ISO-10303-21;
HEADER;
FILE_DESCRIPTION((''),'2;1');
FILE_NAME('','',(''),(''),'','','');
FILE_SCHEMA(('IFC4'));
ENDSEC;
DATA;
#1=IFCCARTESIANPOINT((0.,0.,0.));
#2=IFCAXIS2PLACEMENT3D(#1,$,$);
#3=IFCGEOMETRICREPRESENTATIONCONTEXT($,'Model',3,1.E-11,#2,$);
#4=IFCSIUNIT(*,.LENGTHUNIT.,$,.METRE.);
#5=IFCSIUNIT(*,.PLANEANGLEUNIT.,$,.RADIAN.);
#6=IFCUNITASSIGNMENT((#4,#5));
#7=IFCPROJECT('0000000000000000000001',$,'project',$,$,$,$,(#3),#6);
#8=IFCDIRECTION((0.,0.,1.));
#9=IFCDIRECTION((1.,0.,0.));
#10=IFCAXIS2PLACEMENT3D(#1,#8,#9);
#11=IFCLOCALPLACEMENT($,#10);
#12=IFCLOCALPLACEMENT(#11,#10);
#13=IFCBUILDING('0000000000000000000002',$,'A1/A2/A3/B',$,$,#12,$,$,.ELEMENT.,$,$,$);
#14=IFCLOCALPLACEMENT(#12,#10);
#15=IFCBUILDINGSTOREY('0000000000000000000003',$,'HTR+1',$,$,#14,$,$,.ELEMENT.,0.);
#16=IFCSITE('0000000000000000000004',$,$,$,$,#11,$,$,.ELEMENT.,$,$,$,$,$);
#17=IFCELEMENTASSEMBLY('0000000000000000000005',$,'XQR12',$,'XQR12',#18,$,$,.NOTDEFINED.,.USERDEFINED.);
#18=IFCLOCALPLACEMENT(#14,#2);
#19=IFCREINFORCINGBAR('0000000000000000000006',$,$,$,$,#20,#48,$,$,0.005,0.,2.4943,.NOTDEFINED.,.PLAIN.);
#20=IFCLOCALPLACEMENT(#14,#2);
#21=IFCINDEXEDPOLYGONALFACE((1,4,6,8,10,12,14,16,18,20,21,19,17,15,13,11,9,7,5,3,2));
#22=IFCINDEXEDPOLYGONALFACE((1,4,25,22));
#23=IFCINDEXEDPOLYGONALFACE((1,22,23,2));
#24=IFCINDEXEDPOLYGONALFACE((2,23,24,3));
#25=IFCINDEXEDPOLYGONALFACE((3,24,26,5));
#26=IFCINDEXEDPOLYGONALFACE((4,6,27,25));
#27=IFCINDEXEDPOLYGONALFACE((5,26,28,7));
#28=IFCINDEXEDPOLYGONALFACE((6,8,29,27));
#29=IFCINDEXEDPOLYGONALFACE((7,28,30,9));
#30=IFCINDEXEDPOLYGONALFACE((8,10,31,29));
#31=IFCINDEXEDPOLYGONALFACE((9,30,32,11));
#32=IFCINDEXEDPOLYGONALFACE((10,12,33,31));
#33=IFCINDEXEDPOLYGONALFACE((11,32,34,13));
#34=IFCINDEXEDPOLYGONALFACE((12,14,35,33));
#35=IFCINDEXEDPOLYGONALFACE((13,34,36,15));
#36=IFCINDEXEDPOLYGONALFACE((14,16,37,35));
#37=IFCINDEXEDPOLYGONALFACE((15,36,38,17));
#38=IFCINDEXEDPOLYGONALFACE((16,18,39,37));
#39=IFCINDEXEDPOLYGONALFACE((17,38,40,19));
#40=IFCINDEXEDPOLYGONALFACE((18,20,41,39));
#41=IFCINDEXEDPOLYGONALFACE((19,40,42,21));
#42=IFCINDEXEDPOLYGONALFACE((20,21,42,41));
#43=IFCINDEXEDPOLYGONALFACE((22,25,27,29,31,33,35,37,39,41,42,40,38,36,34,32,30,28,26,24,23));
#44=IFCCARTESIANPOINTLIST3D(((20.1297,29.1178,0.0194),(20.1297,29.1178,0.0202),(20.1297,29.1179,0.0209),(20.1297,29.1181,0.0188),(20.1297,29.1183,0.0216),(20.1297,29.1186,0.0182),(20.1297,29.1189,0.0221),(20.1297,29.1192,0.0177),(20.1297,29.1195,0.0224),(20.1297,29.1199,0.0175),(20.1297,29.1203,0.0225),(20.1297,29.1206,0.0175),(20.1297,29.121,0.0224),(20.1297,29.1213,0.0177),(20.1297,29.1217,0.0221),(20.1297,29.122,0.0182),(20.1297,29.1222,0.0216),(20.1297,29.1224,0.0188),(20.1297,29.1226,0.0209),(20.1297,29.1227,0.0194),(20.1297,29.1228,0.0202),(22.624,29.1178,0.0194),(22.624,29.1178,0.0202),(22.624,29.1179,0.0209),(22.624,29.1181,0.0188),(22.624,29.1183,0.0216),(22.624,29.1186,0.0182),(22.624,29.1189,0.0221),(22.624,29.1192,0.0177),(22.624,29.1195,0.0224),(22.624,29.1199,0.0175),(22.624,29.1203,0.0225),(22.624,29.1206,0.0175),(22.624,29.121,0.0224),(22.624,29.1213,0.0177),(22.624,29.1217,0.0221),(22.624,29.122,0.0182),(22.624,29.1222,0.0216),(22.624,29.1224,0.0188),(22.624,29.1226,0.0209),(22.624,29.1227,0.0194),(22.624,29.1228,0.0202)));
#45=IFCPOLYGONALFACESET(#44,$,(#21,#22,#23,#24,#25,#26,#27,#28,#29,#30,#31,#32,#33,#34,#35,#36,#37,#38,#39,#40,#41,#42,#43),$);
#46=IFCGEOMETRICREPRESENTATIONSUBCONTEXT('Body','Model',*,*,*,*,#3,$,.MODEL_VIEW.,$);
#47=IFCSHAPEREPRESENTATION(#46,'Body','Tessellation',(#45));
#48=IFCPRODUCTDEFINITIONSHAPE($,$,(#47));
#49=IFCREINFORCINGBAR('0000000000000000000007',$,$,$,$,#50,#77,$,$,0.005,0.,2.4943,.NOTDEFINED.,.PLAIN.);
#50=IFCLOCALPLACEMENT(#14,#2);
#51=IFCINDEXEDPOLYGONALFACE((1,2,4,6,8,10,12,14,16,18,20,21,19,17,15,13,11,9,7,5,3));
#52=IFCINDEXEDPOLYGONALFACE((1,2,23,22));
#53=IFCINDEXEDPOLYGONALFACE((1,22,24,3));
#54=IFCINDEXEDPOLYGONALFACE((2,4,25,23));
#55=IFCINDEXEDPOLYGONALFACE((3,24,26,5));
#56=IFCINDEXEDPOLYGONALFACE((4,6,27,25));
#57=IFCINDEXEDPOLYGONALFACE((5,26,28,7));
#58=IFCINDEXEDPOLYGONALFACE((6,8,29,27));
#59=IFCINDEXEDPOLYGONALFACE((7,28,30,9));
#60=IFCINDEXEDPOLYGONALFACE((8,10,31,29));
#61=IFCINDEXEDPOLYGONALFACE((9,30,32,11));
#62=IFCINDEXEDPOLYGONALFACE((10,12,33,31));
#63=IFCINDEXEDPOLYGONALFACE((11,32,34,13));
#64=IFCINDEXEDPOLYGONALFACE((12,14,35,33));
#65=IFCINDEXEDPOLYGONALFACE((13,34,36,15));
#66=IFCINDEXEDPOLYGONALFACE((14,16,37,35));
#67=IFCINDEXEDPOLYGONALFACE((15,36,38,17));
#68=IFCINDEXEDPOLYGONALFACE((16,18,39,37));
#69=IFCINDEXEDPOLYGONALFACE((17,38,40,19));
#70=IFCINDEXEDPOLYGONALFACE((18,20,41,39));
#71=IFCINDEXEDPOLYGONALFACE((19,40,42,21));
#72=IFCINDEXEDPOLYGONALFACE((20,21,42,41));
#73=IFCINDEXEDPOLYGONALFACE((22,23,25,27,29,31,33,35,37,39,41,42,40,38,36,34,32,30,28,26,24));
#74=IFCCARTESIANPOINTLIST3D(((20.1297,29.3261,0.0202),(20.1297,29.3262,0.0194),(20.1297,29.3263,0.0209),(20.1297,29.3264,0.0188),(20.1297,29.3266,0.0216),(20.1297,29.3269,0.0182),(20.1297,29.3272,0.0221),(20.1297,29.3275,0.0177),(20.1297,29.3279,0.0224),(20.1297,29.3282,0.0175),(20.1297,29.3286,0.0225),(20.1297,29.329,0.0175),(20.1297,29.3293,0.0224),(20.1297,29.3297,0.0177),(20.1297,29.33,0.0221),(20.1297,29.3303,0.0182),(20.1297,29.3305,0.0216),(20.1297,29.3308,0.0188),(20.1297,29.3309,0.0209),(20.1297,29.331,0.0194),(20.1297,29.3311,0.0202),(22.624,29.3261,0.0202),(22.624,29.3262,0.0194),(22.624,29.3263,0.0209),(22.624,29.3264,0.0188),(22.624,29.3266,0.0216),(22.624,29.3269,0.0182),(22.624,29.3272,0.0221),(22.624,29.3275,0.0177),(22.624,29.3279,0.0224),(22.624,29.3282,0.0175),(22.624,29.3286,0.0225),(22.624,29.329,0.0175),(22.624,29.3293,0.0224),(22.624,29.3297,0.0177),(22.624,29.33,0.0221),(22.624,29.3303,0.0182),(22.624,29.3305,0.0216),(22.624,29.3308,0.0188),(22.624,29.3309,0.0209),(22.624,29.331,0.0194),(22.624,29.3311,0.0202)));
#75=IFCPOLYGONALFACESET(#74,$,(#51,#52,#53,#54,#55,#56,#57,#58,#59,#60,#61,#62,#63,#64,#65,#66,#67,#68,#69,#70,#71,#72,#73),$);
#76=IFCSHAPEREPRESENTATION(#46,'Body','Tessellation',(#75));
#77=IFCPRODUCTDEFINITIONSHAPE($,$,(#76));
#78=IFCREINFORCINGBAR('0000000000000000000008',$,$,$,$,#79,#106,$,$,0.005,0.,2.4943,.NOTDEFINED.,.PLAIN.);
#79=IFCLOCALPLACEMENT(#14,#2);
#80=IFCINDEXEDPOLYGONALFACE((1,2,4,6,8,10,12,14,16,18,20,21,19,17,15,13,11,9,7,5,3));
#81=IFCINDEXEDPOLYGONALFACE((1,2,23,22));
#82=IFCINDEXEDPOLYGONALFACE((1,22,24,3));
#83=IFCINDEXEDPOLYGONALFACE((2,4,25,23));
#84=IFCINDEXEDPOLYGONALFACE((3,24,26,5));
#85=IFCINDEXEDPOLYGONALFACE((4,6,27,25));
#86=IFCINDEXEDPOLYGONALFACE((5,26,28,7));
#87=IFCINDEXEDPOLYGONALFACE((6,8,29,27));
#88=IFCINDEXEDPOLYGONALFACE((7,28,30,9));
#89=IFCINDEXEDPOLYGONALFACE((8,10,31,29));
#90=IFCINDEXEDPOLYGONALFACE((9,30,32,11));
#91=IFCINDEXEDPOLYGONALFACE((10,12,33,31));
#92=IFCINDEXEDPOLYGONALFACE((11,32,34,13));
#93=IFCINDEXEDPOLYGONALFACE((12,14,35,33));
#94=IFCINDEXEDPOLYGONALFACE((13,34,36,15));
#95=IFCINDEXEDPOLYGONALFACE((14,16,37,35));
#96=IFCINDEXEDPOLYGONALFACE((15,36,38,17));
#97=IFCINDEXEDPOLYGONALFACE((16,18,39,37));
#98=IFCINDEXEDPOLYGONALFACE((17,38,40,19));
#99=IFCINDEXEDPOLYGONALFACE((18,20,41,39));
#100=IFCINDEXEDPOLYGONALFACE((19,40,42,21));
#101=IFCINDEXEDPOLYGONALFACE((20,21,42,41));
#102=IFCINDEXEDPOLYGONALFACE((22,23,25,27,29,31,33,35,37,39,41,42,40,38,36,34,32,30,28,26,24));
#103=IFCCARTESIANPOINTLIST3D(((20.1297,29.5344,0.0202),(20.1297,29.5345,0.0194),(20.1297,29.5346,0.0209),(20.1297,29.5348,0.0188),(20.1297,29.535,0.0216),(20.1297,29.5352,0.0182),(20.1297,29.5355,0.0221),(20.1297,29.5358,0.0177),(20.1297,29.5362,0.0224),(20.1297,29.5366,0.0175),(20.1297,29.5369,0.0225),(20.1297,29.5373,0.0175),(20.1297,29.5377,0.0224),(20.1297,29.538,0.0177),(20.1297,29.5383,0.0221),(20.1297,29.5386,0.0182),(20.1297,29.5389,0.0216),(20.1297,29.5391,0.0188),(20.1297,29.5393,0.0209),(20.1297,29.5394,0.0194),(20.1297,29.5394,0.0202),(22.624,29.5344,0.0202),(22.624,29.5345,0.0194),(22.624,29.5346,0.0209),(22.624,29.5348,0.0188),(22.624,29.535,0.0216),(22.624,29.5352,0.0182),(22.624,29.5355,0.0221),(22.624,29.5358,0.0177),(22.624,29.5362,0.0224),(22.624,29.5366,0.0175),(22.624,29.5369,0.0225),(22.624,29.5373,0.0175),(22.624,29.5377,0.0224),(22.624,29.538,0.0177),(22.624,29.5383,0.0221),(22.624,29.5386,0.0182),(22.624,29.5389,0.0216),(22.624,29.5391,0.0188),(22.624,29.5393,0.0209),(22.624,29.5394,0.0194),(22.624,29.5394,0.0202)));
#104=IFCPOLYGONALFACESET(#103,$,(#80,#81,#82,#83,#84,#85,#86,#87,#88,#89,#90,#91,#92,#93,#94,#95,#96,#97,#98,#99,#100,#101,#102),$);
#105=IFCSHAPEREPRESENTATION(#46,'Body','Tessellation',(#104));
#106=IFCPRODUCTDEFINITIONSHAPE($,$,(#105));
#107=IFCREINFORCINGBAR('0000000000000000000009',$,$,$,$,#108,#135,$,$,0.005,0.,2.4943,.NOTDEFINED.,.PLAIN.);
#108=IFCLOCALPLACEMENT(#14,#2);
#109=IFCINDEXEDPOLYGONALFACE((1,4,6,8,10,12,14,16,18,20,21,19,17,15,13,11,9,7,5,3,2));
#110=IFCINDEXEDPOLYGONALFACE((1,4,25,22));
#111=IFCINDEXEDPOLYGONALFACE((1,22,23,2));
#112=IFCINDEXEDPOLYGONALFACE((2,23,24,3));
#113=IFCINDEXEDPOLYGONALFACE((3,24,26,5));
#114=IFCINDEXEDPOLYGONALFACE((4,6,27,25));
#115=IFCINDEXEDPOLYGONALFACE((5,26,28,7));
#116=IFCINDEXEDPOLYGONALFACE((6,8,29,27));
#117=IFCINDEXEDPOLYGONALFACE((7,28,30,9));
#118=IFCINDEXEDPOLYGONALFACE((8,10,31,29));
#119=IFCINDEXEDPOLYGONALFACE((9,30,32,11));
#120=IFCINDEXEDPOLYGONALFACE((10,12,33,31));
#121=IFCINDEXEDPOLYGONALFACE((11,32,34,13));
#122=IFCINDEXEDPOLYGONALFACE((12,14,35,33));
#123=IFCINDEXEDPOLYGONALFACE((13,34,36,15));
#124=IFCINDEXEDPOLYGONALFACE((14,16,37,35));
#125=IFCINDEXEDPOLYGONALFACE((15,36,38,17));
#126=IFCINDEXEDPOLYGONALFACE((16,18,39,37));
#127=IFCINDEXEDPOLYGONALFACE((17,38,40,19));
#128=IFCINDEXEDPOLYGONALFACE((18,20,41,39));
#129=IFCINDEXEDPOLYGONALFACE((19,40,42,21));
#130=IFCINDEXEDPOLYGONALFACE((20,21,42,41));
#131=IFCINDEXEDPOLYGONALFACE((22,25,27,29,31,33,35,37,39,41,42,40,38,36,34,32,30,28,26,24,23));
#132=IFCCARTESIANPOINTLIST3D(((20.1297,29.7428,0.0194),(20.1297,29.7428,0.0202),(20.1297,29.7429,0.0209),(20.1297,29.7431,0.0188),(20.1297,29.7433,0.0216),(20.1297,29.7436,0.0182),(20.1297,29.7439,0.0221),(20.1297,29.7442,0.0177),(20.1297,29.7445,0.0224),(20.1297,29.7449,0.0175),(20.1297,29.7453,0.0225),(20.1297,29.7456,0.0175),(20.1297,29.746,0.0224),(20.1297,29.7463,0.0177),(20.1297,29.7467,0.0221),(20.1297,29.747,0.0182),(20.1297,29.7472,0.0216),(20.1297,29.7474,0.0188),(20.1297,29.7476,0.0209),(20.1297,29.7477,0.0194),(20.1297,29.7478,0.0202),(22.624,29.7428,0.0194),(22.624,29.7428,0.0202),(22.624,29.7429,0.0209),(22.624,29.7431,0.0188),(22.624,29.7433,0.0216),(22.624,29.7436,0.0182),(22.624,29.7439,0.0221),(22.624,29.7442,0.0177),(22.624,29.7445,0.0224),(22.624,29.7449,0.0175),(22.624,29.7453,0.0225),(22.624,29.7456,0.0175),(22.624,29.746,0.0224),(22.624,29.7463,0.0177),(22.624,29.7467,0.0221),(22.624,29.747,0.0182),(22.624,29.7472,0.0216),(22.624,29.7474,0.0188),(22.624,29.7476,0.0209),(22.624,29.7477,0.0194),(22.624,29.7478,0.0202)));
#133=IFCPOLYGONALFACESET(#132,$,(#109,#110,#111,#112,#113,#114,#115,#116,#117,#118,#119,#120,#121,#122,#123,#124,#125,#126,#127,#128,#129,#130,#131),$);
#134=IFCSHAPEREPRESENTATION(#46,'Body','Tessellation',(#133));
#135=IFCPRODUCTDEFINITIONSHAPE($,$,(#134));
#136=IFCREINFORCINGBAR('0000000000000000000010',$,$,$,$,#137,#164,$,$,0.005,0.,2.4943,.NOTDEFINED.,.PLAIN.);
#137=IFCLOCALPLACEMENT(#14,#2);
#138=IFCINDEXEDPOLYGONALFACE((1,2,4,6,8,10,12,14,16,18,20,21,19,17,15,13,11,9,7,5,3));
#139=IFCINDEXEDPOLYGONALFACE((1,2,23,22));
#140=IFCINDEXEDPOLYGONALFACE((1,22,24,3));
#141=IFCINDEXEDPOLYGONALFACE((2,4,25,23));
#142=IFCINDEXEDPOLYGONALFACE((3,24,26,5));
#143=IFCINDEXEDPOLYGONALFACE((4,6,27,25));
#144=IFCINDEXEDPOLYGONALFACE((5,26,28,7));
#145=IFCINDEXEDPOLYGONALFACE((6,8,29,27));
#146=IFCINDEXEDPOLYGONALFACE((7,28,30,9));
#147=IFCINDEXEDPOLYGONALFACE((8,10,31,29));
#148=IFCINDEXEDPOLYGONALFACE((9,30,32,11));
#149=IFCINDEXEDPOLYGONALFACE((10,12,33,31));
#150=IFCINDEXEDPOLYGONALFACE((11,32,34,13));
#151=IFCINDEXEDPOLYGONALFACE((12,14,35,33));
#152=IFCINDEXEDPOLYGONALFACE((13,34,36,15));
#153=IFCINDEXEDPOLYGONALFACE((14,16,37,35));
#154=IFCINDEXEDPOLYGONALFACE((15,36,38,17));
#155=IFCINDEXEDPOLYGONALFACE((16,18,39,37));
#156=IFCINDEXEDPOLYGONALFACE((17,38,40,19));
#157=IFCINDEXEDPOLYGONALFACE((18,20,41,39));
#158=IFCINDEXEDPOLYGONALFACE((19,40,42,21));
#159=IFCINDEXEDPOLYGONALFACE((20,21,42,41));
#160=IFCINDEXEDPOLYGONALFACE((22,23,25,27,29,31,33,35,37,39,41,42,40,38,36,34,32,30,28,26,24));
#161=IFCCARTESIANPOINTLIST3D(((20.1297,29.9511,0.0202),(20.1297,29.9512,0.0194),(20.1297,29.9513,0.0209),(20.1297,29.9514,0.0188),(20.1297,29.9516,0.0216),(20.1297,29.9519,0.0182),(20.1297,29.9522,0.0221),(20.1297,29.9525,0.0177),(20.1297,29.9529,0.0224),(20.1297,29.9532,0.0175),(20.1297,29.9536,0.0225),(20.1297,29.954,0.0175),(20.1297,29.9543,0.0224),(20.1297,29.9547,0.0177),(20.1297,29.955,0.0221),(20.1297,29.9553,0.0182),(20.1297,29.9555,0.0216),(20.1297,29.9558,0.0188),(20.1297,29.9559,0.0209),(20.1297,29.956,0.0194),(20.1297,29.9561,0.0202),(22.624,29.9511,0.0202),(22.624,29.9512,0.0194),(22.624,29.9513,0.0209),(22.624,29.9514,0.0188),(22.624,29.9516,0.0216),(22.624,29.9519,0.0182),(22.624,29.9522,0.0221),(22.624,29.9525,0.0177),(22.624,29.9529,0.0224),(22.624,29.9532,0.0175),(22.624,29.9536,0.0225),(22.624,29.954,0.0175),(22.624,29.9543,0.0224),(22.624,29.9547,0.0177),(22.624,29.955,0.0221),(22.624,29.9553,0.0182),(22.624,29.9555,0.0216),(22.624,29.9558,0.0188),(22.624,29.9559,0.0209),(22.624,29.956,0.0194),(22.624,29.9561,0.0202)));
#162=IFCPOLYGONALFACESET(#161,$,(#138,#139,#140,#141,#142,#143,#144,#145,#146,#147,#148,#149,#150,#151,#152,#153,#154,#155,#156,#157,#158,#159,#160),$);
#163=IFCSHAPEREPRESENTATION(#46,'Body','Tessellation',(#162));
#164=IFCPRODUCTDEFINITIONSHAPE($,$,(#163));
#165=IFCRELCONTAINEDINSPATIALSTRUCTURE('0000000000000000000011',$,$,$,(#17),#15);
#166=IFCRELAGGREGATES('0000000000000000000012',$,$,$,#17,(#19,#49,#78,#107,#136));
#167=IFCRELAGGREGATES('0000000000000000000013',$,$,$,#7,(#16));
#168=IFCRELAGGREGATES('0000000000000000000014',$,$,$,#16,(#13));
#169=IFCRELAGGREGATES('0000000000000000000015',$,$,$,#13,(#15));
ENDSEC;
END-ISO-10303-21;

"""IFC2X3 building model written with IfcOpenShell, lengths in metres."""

from ifc_helpers import new_model, entity, si_unit, origin, origin_with_axes, place, context, subcontext, project, spatial, shape, element, aggregate, save


model = new_model("IFC2X3")

# Units and contexts
model_context = context("Model", 3, precision=1e-11, world=origin())
body_context = subcontext(model_context, "Body", "Model", "MODEL_VIEW")
ifc_project = project(units=[si_unit("LENGTHUNIT", "METRE"), si_unit("PLANEANGLEUNIT", "RADIAN")], contexts=[model_context])

# Site, building, storey
site_placement = place(None, origin_with_axes())
site = spatial("IfcSite", under=ifc_project, at=site_placement, CompositionType="ELEMENT")
building_placement = place(site_placement, origin_with_axes())
building = spatial("IfcBuilding", under=site, at=building_placement, Name="A1/A2/A3/B", CompositionType="ELEMENT")
storey_placement = place(building_placement, origin_with_axes())
storey = spatial("IfcBuildingStorey", under=building, at=storey_placement, Name="HTR+1", CompositionType="ELEMENT", Elevation=0.0)

# Element assembly, reinforcing bars
assembly_1_placement = place(storey_placement, origin_with_axes())
assembly_1 = element("IfcElementAssembly", 1, at=assembly_1_placement, inside=storey, Name="XQR12", ObjectType="XQR12", AssemblyPlace="NOTDEFINED", PredefinedType="USERDEFINED")
reinforcing_bar_1_placement = place(assembly_1_placement, origin_with_axes())
reinforcing_bar_1 = element("IfcReinforcingBar", 2, at=reinforcing_bar_1_placement, BarLength=2.4943, BarRole="NOTDEFINED", BarSurface="PLAIN", CrossSectionArea=0.0, NominalDiameter=0.005, shapes=[
    shape(body_context, "Body", "AdvancedSweptSolid", [entity("IfcSweptDiskSolid", entity("IfcPolyline", [entity("IfcCartesianPoint", [20.1297, 29.1203, 0.02]), entity("IfcCartesianPoint", [22.624, 29.1203, 0.02])]), 0.0025, None, 0.0, 2.4943)]),
    shape(body_context, "Body", "AdvancedSweptSolid", [entity("IfcSweptDiskSolid", entity("IfcPolyline", [entity("IfcCartesianPoint", [20.1297, 29.1203, 0.02]), entity("IfcCartesianPoint", [22.624, 29.1203, 0.02])]), 0.0025, None, 0.0, 2.4943)]),
])
reinforcing_bar_2_placement = place(assembly_1_placement, origin_with_axes())
reinforcing_bar_2 = element("IfcReinforcingBar", 3, at=reinforcing_bar_2_placement, BarLength=2.4943, BarRole="NOTDEFINED", BarSurface="PLAIN", CrossSectionArea=0.0, NominalDiameter=0.005, shapes=[
    shape(body_context, "Body", "AdvancedSweptSolid", [entity("IfcSweptDiskSolid", entity("IfcPolyline", [entity("IfcCartesianPoint", [20.1297, 29.3286, 0.02]), entity("IfcCartesianPoint", [22.624, 29.3286, 0.02])]), 0.0025, None, 0.0, 2.4943)]),
    shape(body_context, "Body", "AdvancedSweptSolid", [entity("IfcSweptDiskSolid", entity("IfcPolyline", [entity("IfcCartesianPoint", [20.1297, 29.3286, 0.02]), entity("IfcCartesianPoint", [22.624, 29.3286, 0.02])]), 0.0025, None, 0.0, 2.4943)]),
])
reinforcing_bar_3_placement = place(assembly_1_placement, origin_with_axes())
reinforcing_bar_3 = element("IfcReinforcingBar", 4, at=reinforcing_bar_3_placement, BarLength=2.4943, BarRole="NOTDEFINED", BarSurface="PLAIN", CrossSectionArea=0.0, NominalDiameter=0.005, shapes=[
    shape(body_context, "Body", "AdvancedSweptSolid", [entity("IfcSweptDiskSolid", entity("IfcPolyline", [entity("IfcCartesianPoint", [20.1297, 29.5369, 0.02]), entity("IfcCartesianPoint", [22.624, 29.5369, 0.02])]), 0.0025, None, 0.0, 2.4943)]),
    shape(body_context, "Body", "AdvancedSweptSolid", [entity("IfcSweptDiskSolid", entity("IfcPolyline", [entity("IfcCartesianPoint", [20.1297, 29.5369, 0.02]), entity("IfcCartesianPoint", [22.624, 29.5369, 0.02])]), 0.0025, None, 0.0, 2.4943)]),
])
reinforcing_bar_4_placement = place(assembly_1_placement, origin_with_axes())
reinforcing_bar_4 = element("IfcReinforcingBar", 5, at=reinforcing_bar_4_placement, BarLength=2.4943, BarRole="NOTDEFINED", BarSurface="PLAIN", CrossSectionArea=0.0, NominalDiameter=0.005, shapes=[
    shape(body_context, "Body", "AdvancedSweptSolid", [entity("IfcSweptDiskSolid", entity("IfcPolyline", [entity("IfcCartesianPoint", [20.1297, 29.7453, 0.02]), entity("IfcCartesianPoint", [22.624, 29.7453, 0.02])]), 0.0025, None, 0.0, 2.4943)]),
    shape(body_context, "Body", "AdvancedSweptSolid", [entity("IfcSweptDiskSolid", entity("IfcPolyline", [entity("IfcCartesianPoint", [20.1297, 29.7453, 0.02]), entity("IfcCartesianPoint", [22.624, 29.7453, 0.02])]), 0.0025, None, 0.0, 2.4943)]),
])
reinforcing_bar_5_placement = place(assembly_1_placement, origin_with_axes())
reinforcing_bar_5 = element("IfcReinforcingBar", 6, at=reinforcing_bar_5_placement, BarLength=2.4943, BarRole="NOTDEFINED", BarSurface="PLAIN", CrossSectionArea=0.0, NominalDiameter=0.005, shapes=[
    shape(body_context, "Body", "AdvancedSweptSolid", [entity("IfcSweptDiskSolid", entity("IfcPolyline", [entity("IfcCartesianPoint", [20.1297, 29.9536, 0.02]), entity("IfcCartesianPoint", [22.624, 29.9536, 0.02])]), 0.0025, None, 0.0, 2.4943)]),
    shape(body_context, "Body", "AdvancedSweptSolid", [entity("IfcSweptDiskSolid", entity("IfcPolyline", [entity("IfcCartesianPoint", [20.1297, 29.9536, 0.02]), entity("IfcCartesianPoint", [22.624, 29.9536, 0.02])]), 0.0025, None, 0.0, 2.4943)]),
])
aggregate(assembly_1, [reinforcing_bar_1, reinforcing_bar_2, reinforcing_bar_3, reinforcing_bar_4, reinforcing_bar_5])

save(model, "model.ifc")
